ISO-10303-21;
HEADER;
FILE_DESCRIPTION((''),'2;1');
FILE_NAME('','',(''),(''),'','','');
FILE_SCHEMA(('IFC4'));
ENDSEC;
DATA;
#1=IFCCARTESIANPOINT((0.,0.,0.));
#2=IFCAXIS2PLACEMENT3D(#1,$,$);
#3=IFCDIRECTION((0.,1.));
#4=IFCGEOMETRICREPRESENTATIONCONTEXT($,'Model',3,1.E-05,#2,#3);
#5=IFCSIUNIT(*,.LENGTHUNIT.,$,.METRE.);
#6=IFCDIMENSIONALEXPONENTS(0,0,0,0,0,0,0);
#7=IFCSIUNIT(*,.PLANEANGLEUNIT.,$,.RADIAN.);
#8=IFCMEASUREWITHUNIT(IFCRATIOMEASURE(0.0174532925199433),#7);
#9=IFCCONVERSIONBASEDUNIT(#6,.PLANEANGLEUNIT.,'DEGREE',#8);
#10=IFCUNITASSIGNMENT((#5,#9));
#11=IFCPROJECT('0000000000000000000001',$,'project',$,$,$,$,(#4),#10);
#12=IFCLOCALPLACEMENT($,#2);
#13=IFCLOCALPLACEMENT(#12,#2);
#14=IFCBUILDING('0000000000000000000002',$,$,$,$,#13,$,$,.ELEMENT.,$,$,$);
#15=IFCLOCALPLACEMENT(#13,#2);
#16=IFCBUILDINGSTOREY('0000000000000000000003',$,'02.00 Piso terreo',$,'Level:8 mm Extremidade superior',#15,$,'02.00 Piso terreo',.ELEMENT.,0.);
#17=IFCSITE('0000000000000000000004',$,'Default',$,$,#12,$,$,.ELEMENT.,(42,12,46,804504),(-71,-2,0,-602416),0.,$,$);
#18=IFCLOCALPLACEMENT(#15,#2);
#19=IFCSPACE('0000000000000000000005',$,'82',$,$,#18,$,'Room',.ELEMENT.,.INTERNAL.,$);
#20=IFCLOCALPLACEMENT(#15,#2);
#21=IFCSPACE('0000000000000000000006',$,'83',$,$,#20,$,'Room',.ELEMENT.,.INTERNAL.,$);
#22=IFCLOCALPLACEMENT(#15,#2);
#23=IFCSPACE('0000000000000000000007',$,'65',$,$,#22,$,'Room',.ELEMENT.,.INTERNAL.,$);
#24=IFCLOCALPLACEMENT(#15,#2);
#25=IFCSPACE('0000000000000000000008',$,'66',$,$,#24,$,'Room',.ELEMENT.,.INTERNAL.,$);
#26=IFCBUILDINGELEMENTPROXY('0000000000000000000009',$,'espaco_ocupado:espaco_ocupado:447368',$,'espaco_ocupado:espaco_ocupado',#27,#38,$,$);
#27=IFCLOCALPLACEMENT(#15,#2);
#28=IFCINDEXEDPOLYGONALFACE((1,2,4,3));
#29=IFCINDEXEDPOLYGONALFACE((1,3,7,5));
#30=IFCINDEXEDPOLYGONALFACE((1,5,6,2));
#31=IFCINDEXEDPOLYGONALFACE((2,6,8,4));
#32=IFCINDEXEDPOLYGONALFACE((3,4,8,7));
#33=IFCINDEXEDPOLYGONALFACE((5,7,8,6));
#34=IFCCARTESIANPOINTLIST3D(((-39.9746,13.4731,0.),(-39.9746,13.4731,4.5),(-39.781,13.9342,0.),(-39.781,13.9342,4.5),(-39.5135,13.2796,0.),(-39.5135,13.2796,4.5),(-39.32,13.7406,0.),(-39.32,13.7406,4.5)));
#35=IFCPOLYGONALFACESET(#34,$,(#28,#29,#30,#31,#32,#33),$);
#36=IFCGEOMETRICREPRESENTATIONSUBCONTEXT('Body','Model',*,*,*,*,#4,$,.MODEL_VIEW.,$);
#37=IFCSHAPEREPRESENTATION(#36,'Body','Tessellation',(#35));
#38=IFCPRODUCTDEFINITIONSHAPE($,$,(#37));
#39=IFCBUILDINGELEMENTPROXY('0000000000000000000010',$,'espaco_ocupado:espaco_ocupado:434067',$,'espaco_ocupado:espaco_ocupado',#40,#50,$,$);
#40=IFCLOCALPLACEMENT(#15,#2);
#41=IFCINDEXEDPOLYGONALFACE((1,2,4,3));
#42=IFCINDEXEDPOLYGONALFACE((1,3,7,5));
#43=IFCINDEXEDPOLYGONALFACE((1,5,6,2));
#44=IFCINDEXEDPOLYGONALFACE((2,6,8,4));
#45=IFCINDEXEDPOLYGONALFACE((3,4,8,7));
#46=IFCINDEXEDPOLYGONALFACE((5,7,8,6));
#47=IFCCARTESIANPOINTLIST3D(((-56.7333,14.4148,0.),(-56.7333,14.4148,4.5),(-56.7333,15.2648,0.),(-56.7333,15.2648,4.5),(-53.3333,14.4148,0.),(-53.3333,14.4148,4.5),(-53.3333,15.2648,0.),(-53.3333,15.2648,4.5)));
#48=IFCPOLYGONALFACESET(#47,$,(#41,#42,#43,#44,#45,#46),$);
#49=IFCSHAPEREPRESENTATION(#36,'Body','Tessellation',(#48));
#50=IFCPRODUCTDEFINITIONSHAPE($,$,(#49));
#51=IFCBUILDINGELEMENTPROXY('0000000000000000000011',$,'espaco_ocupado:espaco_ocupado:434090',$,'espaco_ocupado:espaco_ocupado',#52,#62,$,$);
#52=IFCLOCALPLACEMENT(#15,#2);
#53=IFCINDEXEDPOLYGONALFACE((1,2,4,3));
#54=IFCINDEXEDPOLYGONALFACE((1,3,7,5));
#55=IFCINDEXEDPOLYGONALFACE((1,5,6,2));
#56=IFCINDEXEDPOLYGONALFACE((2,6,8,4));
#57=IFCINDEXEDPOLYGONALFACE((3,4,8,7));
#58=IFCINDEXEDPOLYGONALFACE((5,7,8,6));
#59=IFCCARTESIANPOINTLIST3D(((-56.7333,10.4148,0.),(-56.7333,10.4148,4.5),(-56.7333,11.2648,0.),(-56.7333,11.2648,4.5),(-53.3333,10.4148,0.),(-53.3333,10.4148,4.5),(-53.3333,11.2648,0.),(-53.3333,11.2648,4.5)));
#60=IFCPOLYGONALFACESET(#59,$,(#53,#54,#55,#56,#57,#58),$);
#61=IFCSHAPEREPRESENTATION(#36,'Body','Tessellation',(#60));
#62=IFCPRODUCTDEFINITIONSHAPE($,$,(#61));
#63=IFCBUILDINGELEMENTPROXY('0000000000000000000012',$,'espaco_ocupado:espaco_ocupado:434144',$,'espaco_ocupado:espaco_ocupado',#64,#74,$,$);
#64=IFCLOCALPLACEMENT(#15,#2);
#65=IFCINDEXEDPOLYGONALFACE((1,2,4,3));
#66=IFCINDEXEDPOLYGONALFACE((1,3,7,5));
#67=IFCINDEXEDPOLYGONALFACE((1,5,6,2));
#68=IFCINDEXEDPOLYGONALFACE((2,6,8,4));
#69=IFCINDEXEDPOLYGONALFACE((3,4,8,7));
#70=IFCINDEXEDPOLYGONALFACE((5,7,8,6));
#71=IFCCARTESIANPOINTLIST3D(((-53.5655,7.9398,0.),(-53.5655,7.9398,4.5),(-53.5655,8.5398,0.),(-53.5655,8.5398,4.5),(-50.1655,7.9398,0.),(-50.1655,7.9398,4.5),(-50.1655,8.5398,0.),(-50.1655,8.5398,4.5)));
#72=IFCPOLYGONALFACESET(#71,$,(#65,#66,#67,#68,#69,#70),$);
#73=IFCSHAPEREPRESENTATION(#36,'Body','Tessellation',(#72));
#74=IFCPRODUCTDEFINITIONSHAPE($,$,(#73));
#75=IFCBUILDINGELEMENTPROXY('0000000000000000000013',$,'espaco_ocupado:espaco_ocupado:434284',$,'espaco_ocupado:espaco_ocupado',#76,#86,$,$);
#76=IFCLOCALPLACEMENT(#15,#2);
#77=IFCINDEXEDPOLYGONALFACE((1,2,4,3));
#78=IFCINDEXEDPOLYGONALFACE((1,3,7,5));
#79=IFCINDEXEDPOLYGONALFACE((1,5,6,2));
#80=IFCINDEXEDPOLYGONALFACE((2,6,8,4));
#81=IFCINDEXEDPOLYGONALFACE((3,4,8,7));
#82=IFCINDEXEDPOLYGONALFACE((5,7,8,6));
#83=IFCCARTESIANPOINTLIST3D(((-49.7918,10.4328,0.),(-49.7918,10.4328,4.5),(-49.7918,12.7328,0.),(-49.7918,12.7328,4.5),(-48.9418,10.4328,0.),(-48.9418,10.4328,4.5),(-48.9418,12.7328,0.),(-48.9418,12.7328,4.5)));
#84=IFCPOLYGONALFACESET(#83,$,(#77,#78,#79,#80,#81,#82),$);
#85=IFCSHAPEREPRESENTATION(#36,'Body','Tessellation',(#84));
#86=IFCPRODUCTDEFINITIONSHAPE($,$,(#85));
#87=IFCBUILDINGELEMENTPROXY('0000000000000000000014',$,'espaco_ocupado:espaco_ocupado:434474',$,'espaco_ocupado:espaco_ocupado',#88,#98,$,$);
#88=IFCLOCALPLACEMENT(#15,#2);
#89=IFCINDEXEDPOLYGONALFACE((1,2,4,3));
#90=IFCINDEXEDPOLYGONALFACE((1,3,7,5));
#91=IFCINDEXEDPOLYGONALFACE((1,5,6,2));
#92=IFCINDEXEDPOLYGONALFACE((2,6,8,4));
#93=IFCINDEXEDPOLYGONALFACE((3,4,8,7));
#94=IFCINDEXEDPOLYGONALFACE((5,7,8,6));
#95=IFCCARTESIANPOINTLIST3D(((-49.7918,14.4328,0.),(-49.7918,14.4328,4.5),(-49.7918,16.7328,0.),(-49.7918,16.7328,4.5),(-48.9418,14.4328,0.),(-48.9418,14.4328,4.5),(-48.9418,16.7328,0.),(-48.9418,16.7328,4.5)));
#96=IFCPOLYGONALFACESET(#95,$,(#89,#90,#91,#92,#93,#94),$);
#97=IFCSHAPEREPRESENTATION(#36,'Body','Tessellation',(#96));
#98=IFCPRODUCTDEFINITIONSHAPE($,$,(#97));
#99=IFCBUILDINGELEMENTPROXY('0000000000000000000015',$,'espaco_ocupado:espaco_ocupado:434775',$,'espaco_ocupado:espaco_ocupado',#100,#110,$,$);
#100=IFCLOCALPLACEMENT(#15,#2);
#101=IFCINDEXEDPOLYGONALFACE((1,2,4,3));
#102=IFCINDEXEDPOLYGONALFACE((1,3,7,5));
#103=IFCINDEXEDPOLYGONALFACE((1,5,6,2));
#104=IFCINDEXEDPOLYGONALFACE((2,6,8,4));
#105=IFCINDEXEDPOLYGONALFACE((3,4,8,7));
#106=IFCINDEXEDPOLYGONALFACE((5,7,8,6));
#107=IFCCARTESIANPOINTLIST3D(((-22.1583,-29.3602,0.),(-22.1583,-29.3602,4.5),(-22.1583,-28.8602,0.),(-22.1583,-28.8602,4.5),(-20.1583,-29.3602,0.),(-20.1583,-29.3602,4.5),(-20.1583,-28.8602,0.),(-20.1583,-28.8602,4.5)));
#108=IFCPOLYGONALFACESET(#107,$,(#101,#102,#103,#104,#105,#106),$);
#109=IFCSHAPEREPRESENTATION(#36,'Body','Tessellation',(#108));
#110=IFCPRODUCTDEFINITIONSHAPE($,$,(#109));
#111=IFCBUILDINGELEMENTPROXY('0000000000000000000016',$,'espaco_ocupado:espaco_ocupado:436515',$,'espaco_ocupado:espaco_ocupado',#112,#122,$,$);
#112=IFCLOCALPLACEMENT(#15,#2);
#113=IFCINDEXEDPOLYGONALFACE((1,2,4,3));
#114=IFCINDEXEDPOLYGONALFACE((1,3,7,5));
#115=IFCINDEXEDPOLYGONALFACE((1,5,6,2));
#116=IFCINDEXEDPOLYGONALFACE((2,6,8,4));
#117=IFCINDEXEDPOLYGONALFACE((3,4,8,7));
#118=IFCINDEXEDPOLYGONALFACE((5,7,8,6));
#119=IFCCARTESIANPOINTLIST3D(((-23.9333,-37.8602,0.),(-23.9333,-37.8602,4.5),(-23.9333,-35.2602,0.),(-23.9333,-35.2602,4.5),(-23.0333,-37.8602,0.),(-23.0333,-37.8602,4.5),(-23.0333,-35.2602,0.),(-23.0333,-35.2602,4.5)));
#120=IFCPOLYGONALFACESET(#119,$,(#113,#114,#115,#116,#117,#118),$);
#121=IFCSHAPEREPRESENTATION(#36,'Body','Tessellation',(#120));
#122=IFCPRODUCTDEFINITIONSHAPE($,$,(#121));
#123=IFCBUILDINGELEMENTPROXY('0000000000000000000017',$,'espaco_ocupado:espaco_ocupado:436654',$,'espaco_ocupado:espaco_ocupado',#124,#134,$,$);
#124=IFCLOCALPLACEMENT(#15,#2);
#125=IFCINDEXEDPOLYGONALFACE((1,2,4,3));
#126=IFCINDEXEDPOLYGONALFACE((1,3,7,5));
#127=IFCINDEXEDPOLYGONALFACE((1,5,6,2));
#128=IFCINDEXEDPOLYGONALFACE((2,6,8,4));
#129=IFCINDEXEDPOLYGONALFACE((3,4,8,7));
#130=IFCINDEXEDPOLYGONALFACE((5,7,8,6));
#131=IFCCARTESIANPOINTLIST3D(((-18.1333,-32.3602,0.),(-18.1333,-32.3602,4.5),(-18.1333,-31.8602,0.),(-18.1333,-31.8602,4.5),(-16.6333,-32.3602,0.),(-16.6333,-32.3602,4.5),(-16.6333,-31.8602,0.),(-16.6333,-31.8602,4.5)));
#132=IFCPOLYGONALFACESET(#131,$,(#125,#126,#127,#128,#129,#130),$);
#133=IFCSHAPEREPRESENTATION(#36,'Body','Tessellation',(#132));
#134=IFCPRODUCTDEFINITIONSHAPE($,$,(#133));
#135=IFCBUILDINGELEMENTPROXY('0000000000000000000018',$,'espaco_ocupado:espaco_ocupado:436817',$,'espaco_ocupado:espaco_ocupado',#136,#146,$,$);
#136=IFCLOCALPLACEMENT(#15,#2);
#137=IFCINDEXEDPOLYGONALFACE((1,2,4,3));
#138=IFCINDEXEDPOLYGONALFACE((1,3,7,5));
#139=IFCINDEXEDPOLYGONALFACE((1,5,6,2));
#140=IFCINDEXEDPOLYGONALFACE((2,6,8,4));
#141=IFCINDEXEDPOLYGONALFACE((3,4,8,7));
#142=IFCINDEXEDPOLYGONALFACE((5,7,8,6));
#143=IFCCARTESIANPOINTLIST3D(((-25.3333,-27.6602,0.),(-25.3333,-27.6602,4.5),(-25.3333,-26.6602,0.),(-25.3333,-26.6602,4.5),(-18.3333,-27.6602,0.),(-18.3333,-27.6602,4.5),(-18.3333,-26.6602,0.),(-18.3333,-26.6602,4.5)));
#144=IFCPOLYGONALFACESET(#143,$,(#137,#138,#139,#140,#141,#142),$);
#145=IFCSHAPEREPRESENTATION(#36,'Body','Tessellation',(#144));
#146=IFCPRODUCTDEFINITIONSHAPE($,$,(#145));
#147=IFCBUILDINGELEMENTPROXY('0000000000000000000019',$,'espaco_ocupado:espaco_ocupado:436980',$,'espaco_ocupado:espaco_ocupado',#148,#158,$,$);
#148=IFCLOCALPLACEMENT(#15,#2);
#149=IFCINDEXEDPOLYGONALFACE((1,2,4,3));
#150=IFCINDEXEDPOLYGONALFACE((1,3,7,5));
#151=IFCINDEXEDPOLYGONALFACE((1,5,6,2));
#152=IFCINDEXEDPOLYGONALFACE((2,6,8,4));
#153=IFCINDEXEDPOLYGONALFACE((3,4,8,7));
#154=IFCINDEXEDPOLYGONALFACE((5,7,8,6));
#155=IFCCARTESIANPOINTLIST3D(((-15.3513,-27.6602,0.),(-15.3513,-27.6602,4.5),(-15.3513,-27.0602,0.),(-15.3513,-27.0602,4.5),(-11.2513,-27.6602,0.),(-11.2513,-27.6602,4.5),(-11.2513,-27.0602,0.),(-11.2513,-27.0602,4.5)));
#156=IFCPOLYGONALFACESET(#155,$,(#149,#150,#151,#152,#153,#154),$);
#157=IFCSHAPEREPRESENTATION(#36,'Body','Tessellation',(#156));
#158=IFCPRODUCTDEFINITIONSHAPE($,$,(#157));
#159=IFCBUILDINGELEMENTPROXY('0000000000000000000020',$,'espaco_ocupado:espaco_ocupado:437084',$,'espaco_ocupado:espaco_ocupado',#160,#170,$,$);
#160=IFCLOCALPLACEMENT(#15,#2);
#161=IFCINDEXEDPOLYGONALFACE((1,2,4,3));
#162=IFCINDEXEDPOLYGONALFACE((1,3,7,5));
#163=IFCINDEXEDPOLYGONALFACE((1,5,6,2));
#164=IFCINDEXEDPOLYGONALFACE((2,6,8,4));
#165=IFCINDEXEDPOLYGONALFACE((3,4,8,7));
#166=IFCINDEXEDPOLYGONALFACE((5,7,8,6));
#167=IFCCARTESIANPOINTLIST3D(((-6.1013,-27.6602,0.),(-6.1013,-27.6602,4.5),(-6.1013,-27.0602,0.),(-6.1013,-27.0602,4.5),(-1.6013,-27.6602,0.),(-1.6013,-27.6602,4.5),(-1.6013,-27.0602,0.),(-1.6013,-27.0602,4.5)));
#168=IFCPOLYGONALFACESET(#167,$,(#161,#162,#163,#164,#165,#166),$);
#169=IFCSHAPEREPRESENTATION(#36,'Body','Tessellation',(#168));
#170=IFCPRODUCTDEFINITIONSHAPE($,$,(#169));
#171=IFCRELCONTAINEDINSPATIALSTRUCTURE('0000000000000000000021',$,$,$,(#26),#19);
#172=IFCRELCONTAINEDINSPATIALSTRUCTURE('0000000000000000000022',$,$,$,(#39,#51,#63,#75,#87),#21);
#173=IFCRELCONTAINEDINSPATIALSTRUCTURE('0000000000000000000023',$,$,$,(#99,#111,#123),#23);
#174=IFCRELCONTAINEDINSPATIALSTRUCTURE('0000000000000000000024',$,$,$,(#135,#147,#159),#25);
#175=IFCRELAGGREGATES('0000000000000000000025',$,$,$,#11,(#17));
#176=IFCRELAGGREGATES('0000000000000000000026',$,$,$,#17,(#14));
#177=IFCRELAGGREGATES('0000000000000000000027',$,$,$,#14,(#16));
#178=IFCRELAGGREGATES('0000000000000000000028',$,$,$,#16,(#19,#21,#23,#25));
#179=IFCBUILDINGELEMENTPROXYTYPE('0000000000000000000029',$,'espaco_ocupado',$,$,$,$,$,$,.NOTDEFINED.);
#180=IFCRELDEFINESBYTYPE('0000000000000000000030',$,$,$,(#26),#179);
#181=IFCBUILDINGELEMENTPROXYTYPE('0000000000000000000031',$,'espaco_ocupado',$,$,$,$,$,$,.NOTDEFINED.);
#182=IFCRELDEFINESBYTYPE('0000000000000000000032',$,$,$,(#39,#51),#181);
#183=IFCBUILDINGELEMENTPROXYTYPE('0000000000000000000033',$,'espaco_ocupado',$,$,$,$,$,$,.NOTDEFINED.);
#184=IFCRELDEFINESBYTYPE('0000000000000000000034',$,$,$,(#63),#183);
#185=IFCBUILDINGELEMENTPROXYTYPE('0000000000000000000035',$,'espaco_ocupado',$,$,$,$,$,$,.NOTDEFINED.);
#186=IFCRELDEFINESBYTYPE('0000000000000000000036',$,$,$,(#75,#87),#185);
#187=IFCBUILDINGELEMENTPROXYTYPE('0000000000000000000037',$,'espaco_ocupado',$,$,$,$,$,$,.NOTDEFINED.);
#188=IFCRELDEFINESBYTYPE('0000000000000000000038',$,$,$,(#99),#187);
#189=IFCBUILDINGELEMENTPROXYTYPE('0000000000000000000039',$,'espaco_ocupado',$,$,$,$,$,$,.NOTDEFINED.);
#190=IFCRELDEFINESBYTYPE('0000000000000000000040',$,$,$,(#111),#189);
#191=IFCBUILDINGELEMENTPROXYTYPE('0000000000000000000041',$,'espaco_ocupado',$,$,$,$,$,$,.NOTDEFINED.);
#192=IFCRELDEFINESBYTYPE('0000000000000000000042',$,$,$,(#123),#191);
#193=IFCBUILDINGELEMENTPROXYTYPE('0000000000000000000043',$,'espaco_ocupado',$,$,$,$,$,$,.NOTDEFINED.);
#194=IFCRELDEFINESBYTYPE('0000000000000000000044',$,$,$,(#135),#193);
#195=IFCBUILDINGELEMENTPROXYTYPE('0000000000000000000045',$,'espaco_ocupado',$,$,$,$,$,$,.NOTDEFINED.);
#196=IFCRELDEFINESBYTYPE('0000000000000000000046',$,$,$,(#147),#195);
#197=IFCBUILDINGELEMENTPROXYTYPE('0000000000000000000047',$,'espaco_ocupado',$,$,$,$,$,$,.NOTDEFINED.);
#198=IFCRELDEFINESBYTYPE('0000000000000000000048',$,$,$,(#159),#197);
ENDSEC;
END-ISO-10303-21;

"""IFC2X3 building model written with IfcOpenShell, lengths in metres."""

from ifc_helpers import new_model, entity, si_unit, converted_unit, direction, frame, origin, origin_2d_with_axis, place, context, subcontext, project, spatial, rectangle, extrude, source, transform, mapped, type_object, type_shapes, element, save


model = new_model("IFC2X3")

# Units and contexts
model_context = context("Model", 3, precision=1e-05, world=origin(), true_north=direction((0.0, 1.0)))
body_context = subcontext(model_context, "Body", "Model", "MODEL_VIEW")
ifc_project = project(units=[si_unit("LENGTHUNIT", "METRE"), converted_unit("PLANEANGLEUNIT", "DEGREE", entity("IfcRatioMeasure", 0.0174532925199433), si_unit("PLANEANGLEUNIT", "RADIAN"), dimensions=[0, 0, 0, 0, 0, 0, 0])], contexts=[model_context])

# Site, building, storey, space
site_placement = place(None, origin())
site = spatial("IfcSite", under=ifc_project, at=site_placement, Name="Default", CompositionType="ELEMENT", RefLatitude=(42, 12, 46, 804504), RefLongitude=(-71, -2, 0, -602416), RefElevation=0.0)
building_placement = place(site_placement, origin())
building = spatial("IfcBuilding", under=site, at=building_placement, CompositionType="ELEMENT")
storey_placement = place(building_placement, origin())
storey = spatial("IfcBuildingStorey", under=building, at=storey_placement, Name="02.00 Piso terreo", ObjectType="Level:8 mm Extremidade superior", LongName="02.00 Piso terreo", CompositionType="ELEMENT", Elevation=0.0)
space_1_placement = place(storey_placement, origin())
space_1 = spatial("IfcSpace", under=storey, at=space_1_placement, Name="82", LongName="Room", CompositionType="ELEMENT", InteriorOrExteriorSpace="INTERNAL")

# Building element proxy
building_element_proxy_type_1 = type_object("IfcBuildingElementProxyType", Name="espaco_ocupado", PredefinedType="NOTDEFINED")
shared_shape_1 = source(origin(), body_context, "Body", "SweptSolid", [
    extrude(rectangle(XDim=0.5, YDim=0.5, at=origin_2d_with_axis()), frame((0.0, 0.0, 0.0), z_axis=(0.0, 0.0, 1.0), x_axis=(-1.0, 0.0, 0.0)), (0.0, 0.0, 1.0), 4.5),
])
type_shapes(building_element_proxy_type_1, [shared_shape_1])
proxy_1_placement = place(space_1_placement, frame((-39.6473, 13.6069, 0.0), z_axis=(0.0, 0.0, 1.0), x_axis=(0.387097, 0.922039, 0.0)))
element("IfcBuildingElementProxy", 1, at=proxy_1_placement, inside=space_1, type_object=building_element_proxy_type_1, Name="espaco_ocupado:espaco_ocupado:447368", ObjectType="espaco_ocupado:espaco_ocupado", context=body_context, shape_type="MappedRepresentation", body=[
    mapped(shared_shape_1, transform((0.0, 0.0, 0.0), scale=1.0)),
])

# Shared definitions
space_2_placement = place(storey_placement, origin())
space_2 = spatial("IfcSpace", under=storey, at=space_2_placement, Name="83", LongName="Room", CompositionType="ELEMENT", InteriorOrExteriorSpace="INTERNAL")

# Building element proxies
building_element_proxy_type_2 = type_object("IfcBuildingElementProxyType", Name="espaco_ocupado", PredefinedType="NOTDEFINED")
shared_shape_2 = source(origin(), body_context, "Body", "SweptSolid", [
    extrude(rectangle(XDim=3.4, YDim=0.85, at=origin_2d_with_axis()), frame((0.0, 0.0, 0.0), z_axis=(0.0, 0.0, 1.0), x_axis=(-1.0, 0.0, 0.0)), (0.0, 0.0, 1.0), 4.5),
])
type_shapes(building_element_proxy_type_2, [shared_shape_2])
for number, where, name in (
    (2, (-55.0333, 14.8398, 0.0), "espaco_ocupado:espaco_ocupado:434067"),
    (3, (-55.0333, 10.8398, 0.0), "espaco_ocupado:espaco_ocupado:434090"),
):
    element("IfcBuildingElementProxy", number, at=place(space_2_placement, frame(where)), inside=space_2, type_object=building_element_proxy_type_2, Name=name, ObjectType="espaco_ocupado:espaco_ocupado", context=body_context, shape_type="MappedRepresentation", body=[
        mapped(shared_shape_2, transform((0.0, 0.0, 0.0), scale=1.0)),
    ])
building_element_proxy_type_3 = type_object("IfcBuildingElementProxyType", Name="espaco_ocupado", PredefinedType="NOTDEFINED")
shared_shape_3 = source(origin(), body_context, "Body", "SweptSolid", [
    extrude(rectangle(XDim=3.4, YDim=0.6, at=origin_2d_with_axis()), frame((0.0, 0.0, 0.0), z_axis=(0.0, 0.0, 1.0), x_axis=(-1.0, 0.0, 0.0)), (0.0, 0.0, 1.0), 4.5),
])
type_shapes(building_element_proxy_type_3, [shared_shape_3])
proxy_2_placement = place(space_2_placement, frame((-51.8655, 8.2398, 0.0)))
element("IfcBuildingElementProxy", 4, at=proxy_2_placement, inside=space_2, type_object=building_element_proxy_type_3, Name="espaco_ocupado:espaco_ocupado:434144", ObjectType="espaco_ocupado:espaco_ocupado", context=body_context, shape_type="MappedRepresentation", body=[
    mapped(shared_shape_3, transform((0.0, 0.0, 0.0), scale=1.0)),
])
building_element_proxy_type_4 = type_object("IfcBuildingElementProxyType", Name="espaco_ocupado", PredefinedType="NOTDEFINED")
shared_shape_4 = source(origin(), body_context, "Body", "SweptSolid", [
    extrude(rectangle(XDim=0.85, YDim=2.3, at=origin_2d_with_axis()), frame((0.0, 0.0, 0.0), z_axis=(0.0, 0.0, 1.0), x_axis=(-1.0, 0.0, 0.0)), (0.0, 0.0, 1.0), 4.5),
])
type_shapes(building_element_proxy_type_4, [shared_shape_4])
for number, where, name in (
    (5, (-49.3668, 11.5828, 0.0), "espaco_ocupado:espaco_ocupado:434284"),
    (6, (-49.3668, 15.5828, 0.0), "espaco_ocupado:espaco_ocupado:434474"),
):
    element("IfcBuildingElementProxy", number, at=place(space_2_placement, frame(where)), inside=space_2, type_object=building_element_proxy_type_4, Name=name, ObjectType="espaco_ocupado:espaco_ocupado", context=body_context, shape_type="MappedRepresentation", body=[
        mapped(shared_shape_4, transform((0.0, 0.0, 0.0), scale=1.0)),
    ])

# Shared definitions
space_3_placement = place(storey_placement, origin())
space_3 = spatial("IfcSpace", under=storey, at=space_3_placement, Name="65", LongName="Room", CompositionType="ELEMENT", InteriorOrExteriorSpace="INTERNAL")

# Building element proxies
building_element_proxy_type_5 = type_object("IfcBuildingElementProxyType", Name="espaco_ocupado", PredefinedType="NOTDEFINED")
shared_shape_5 = source(origin(), body_context, "Body", "SweptSolid", [
    extrude(rectangle(XDim=2.0, YDim=0.5, at=origin_2d_with_axis()), frame((0.0, 0.0, 0.0), z_axis=(0.0, 0.0, 1.0), x_axis=(-1.0, 0.0, 0.0)), (0.0, 0.0, 1.0), 4.5),
])
type_shapes(building_element_proxy_type_5, [shared_shape_5])
proxy_3_placement = place(space_3_placement, frame((-21.1583, -29.1102, 0.0)))
element("IfcBuildingElementProxy", 7, at=proxy_3_placement, inside=space_3, type_object=building_element_proxy_type_5, Name="espaco_ocupado:espaco_ocupado:434775", ObjectType="espaco_ocupado:espaco_ocupado", context=body_context, shape_type="MappedRepresentation", body=[
    mapped(shared_shape_5, transform((0.0, 0.0, 0.0), scale=1.0)),
])
building_element_proxy_type_6 = type_object("IfcBuildingElementProxyType", Name="espaco_ocupado", PredefinedType="NOTDEFINED")
shared_shape_6 = source(origin(), body_context, "Body", "SweptSolid", [
    extrude(rectangle(XDim=0.9, YDim=2.6, at=origin_2d_with_axis()), frame((0.0, 0.0, 0.0), z_axis=(0.0, 0.0, 1.0), x_axis=(-1.0, 0.0, 0.0)), (0.0, 0.0, 1.0), 4.5),
])
type_shapes(building_element_proxy_type_6, [shared_shape_6])
proxy_4_placement = place(space_3_placement, frame((-23.4833, -36.5602, 0.0)))
element("IfcBuildingElementProxy", 8, at=proxy_4_placement, inside=space_3, type_object=building_element_proxy_type_6, Name="espaco_ocupado:espaco_ocupado:436515", ObjectType="espaco_ocupado:espaco_ocupado", context=body_context, shape_type="MappedRepresentation", body=[
    mapped(shared_shape_6, transform((0.0, 0.0, 0.0), scale=1.0)),
])
building_element_proxy_type_7 = type_object("IfcBuildingElementProxyType", Name="espaco_ocupado", PredefinedType="NOTDEFINED")
shared_shape_7 = source(origin(), body_context, "Body", "SweptSolid", [
    extrude(rectangle(XDim=1.5, YDim=0.5, at=origin_2d_with_axis()), frame((0.0, 0.0, 0.0), z_axis=(0.0, 0.0, 1.0), x_axis=(-1.0, 0.0, 0.0)), (0.0, 0.0, 1.0), 4.5),
])
type_shapes(building_element_proxy_type_7, [shared_shape_7])
proxy_5_placement = place(space_3_placement, frame((-17.3833, -32.1102, 0.0)))
element("IfcBuildingElementProxy", 9, at=proxy_5_placement, inside=space_3, type_object=building_element_proxy_type_7, Name="espaco_ocupado:espaco_ocupado:436654", ObjectType="espaco_ocupado:espaco_ocupado", context=body_context, shape_type="MappedRepresentation", body=[
    mapped(shared_shape_7, transform((0.0, 0.0, 0.0), scale=1.0)),
])

# Shared definitions
space_4_placement = place(storey_placement, origin())
space_4 = spatial("IfcSpace", under=storey, at=space_4_placement, Name="66", LongName="Room", CompositionType="ELEMENT", InteriorOrExteriorSpace="INTERNAL")

# Building element proxies
building_element_proxy_type_8 = type_object("IfcBuildingElementProxyType", Name="espaco_ocupado", PredefinedType="NOTDEFINED")
shared_shape_8 = source(origin(), body_context, "Body", "SweptSolid", [
    extrude(rectangle(XDim=7.0, YDim=1.0, at=origin_2d_with_axis()), frame((0.0, 0.0, 0.0), z_axis=(0.0, 0.0, 1.0), x_axis=(-1.0, 0.0, 0.0)), (0.0, 0.0, 1.0), 4.5),
])
type_shapes(building_element_proxy_type_8, [shared_shape_8])
proxy_6_placement = place(space_4_placement, frame((-21.8333, -27.1602, 0.0)))
element("IfcBuildingElementProxy", 10, at=proxy_6_placement, inside=space_4, type_object=building_element_proxy_type_8, Name="espaco_ocupado:espaco_ocupado:436817", ObjectType="espaco_ocupado:espaco_ocupado", context=body_context, shape_type="MappedRepresentation", body=[
    mapped(shared_shape_8, transform((0.0, 0.0, 0.0), scale=1.0)),
])
building_element_proxy_type_9 = type_object("IfcBuildingElementProxyType", Name="espaco_ocupado", PredefinedType="NOTDEFINED")
shared_shape_9 = source(origin(), body_context, "Body", "SweptSolid", [
    extrude(rectangle(XDim=4.1, YDim=0.6, at=origin_2d_with_axis()), frame((0.0, 0.0, 0.0), z_axis=(0.0, 0.0, 1.0), x_axis=(-1.0, 0.0, 0.0)), (0.0, 0.0, 1.0), 4.5),
])
type_shapes(building_element_proxy_type_9, [shared_shape_9])
proxy_7_placement = place(space_4_placement, frame((-13.3013, -27.3602, 0.0)))
element("IfcBuildingElementProxy", 11, at=proxy_7_placement, inside=space_4, type_object=building_element_proxy_type_9, Name="espaco_ocupado:espaco_ocupado:436980", ObjectType="espaco_ocupado:espaco_ocupado", context=body_context, shape_type="MappedRepresentation", body=[
    mapped(shared_shape_9, transform((0.0, 0.0, 0.0), scale=1.0)),
])
building_element_proxy_type_10 = type_object("IfcBuildingElementProxyType", Name="espaco_ocupado", PredefinedType="NOTDEFINED")
shared_shape_10 = source(origin(), body_context, "Body", "SweptSolid", [
    extrude(rectangle(XDim=4.5, YDim=0.6, at=origin_2d_with_axis()), frame((0.0, 0.0, 0.0), z_axis=(0.0, 0.0, 1.0), x_axis=(-1.0, 0.0, 0.0)), (0.0, 0.0, 1.0), 4.5),
])
type_shapes(building_element_proxy_type_10, [shared_shape_10])
proxy_8_placement = place(space_4_placement, frame((-3.8513, -27.3602, 0.0)))
element("IfcBuildingElementProxy", 12, at=proxy_8_placement, inside=space_4, type_object=building_element_proxy_type_10, Name="espaco_ocupado:espaco_ocupado:437084", ObjectType="espaco_ocupado:espaco_ocupado", context=body_context, shape_type="MappedRepresentation", body=[
    mapped(shared_shape_10, transform((0.0, 0.0, 0.0), scale=1.0)),
])

save(model, "model.ifc")
